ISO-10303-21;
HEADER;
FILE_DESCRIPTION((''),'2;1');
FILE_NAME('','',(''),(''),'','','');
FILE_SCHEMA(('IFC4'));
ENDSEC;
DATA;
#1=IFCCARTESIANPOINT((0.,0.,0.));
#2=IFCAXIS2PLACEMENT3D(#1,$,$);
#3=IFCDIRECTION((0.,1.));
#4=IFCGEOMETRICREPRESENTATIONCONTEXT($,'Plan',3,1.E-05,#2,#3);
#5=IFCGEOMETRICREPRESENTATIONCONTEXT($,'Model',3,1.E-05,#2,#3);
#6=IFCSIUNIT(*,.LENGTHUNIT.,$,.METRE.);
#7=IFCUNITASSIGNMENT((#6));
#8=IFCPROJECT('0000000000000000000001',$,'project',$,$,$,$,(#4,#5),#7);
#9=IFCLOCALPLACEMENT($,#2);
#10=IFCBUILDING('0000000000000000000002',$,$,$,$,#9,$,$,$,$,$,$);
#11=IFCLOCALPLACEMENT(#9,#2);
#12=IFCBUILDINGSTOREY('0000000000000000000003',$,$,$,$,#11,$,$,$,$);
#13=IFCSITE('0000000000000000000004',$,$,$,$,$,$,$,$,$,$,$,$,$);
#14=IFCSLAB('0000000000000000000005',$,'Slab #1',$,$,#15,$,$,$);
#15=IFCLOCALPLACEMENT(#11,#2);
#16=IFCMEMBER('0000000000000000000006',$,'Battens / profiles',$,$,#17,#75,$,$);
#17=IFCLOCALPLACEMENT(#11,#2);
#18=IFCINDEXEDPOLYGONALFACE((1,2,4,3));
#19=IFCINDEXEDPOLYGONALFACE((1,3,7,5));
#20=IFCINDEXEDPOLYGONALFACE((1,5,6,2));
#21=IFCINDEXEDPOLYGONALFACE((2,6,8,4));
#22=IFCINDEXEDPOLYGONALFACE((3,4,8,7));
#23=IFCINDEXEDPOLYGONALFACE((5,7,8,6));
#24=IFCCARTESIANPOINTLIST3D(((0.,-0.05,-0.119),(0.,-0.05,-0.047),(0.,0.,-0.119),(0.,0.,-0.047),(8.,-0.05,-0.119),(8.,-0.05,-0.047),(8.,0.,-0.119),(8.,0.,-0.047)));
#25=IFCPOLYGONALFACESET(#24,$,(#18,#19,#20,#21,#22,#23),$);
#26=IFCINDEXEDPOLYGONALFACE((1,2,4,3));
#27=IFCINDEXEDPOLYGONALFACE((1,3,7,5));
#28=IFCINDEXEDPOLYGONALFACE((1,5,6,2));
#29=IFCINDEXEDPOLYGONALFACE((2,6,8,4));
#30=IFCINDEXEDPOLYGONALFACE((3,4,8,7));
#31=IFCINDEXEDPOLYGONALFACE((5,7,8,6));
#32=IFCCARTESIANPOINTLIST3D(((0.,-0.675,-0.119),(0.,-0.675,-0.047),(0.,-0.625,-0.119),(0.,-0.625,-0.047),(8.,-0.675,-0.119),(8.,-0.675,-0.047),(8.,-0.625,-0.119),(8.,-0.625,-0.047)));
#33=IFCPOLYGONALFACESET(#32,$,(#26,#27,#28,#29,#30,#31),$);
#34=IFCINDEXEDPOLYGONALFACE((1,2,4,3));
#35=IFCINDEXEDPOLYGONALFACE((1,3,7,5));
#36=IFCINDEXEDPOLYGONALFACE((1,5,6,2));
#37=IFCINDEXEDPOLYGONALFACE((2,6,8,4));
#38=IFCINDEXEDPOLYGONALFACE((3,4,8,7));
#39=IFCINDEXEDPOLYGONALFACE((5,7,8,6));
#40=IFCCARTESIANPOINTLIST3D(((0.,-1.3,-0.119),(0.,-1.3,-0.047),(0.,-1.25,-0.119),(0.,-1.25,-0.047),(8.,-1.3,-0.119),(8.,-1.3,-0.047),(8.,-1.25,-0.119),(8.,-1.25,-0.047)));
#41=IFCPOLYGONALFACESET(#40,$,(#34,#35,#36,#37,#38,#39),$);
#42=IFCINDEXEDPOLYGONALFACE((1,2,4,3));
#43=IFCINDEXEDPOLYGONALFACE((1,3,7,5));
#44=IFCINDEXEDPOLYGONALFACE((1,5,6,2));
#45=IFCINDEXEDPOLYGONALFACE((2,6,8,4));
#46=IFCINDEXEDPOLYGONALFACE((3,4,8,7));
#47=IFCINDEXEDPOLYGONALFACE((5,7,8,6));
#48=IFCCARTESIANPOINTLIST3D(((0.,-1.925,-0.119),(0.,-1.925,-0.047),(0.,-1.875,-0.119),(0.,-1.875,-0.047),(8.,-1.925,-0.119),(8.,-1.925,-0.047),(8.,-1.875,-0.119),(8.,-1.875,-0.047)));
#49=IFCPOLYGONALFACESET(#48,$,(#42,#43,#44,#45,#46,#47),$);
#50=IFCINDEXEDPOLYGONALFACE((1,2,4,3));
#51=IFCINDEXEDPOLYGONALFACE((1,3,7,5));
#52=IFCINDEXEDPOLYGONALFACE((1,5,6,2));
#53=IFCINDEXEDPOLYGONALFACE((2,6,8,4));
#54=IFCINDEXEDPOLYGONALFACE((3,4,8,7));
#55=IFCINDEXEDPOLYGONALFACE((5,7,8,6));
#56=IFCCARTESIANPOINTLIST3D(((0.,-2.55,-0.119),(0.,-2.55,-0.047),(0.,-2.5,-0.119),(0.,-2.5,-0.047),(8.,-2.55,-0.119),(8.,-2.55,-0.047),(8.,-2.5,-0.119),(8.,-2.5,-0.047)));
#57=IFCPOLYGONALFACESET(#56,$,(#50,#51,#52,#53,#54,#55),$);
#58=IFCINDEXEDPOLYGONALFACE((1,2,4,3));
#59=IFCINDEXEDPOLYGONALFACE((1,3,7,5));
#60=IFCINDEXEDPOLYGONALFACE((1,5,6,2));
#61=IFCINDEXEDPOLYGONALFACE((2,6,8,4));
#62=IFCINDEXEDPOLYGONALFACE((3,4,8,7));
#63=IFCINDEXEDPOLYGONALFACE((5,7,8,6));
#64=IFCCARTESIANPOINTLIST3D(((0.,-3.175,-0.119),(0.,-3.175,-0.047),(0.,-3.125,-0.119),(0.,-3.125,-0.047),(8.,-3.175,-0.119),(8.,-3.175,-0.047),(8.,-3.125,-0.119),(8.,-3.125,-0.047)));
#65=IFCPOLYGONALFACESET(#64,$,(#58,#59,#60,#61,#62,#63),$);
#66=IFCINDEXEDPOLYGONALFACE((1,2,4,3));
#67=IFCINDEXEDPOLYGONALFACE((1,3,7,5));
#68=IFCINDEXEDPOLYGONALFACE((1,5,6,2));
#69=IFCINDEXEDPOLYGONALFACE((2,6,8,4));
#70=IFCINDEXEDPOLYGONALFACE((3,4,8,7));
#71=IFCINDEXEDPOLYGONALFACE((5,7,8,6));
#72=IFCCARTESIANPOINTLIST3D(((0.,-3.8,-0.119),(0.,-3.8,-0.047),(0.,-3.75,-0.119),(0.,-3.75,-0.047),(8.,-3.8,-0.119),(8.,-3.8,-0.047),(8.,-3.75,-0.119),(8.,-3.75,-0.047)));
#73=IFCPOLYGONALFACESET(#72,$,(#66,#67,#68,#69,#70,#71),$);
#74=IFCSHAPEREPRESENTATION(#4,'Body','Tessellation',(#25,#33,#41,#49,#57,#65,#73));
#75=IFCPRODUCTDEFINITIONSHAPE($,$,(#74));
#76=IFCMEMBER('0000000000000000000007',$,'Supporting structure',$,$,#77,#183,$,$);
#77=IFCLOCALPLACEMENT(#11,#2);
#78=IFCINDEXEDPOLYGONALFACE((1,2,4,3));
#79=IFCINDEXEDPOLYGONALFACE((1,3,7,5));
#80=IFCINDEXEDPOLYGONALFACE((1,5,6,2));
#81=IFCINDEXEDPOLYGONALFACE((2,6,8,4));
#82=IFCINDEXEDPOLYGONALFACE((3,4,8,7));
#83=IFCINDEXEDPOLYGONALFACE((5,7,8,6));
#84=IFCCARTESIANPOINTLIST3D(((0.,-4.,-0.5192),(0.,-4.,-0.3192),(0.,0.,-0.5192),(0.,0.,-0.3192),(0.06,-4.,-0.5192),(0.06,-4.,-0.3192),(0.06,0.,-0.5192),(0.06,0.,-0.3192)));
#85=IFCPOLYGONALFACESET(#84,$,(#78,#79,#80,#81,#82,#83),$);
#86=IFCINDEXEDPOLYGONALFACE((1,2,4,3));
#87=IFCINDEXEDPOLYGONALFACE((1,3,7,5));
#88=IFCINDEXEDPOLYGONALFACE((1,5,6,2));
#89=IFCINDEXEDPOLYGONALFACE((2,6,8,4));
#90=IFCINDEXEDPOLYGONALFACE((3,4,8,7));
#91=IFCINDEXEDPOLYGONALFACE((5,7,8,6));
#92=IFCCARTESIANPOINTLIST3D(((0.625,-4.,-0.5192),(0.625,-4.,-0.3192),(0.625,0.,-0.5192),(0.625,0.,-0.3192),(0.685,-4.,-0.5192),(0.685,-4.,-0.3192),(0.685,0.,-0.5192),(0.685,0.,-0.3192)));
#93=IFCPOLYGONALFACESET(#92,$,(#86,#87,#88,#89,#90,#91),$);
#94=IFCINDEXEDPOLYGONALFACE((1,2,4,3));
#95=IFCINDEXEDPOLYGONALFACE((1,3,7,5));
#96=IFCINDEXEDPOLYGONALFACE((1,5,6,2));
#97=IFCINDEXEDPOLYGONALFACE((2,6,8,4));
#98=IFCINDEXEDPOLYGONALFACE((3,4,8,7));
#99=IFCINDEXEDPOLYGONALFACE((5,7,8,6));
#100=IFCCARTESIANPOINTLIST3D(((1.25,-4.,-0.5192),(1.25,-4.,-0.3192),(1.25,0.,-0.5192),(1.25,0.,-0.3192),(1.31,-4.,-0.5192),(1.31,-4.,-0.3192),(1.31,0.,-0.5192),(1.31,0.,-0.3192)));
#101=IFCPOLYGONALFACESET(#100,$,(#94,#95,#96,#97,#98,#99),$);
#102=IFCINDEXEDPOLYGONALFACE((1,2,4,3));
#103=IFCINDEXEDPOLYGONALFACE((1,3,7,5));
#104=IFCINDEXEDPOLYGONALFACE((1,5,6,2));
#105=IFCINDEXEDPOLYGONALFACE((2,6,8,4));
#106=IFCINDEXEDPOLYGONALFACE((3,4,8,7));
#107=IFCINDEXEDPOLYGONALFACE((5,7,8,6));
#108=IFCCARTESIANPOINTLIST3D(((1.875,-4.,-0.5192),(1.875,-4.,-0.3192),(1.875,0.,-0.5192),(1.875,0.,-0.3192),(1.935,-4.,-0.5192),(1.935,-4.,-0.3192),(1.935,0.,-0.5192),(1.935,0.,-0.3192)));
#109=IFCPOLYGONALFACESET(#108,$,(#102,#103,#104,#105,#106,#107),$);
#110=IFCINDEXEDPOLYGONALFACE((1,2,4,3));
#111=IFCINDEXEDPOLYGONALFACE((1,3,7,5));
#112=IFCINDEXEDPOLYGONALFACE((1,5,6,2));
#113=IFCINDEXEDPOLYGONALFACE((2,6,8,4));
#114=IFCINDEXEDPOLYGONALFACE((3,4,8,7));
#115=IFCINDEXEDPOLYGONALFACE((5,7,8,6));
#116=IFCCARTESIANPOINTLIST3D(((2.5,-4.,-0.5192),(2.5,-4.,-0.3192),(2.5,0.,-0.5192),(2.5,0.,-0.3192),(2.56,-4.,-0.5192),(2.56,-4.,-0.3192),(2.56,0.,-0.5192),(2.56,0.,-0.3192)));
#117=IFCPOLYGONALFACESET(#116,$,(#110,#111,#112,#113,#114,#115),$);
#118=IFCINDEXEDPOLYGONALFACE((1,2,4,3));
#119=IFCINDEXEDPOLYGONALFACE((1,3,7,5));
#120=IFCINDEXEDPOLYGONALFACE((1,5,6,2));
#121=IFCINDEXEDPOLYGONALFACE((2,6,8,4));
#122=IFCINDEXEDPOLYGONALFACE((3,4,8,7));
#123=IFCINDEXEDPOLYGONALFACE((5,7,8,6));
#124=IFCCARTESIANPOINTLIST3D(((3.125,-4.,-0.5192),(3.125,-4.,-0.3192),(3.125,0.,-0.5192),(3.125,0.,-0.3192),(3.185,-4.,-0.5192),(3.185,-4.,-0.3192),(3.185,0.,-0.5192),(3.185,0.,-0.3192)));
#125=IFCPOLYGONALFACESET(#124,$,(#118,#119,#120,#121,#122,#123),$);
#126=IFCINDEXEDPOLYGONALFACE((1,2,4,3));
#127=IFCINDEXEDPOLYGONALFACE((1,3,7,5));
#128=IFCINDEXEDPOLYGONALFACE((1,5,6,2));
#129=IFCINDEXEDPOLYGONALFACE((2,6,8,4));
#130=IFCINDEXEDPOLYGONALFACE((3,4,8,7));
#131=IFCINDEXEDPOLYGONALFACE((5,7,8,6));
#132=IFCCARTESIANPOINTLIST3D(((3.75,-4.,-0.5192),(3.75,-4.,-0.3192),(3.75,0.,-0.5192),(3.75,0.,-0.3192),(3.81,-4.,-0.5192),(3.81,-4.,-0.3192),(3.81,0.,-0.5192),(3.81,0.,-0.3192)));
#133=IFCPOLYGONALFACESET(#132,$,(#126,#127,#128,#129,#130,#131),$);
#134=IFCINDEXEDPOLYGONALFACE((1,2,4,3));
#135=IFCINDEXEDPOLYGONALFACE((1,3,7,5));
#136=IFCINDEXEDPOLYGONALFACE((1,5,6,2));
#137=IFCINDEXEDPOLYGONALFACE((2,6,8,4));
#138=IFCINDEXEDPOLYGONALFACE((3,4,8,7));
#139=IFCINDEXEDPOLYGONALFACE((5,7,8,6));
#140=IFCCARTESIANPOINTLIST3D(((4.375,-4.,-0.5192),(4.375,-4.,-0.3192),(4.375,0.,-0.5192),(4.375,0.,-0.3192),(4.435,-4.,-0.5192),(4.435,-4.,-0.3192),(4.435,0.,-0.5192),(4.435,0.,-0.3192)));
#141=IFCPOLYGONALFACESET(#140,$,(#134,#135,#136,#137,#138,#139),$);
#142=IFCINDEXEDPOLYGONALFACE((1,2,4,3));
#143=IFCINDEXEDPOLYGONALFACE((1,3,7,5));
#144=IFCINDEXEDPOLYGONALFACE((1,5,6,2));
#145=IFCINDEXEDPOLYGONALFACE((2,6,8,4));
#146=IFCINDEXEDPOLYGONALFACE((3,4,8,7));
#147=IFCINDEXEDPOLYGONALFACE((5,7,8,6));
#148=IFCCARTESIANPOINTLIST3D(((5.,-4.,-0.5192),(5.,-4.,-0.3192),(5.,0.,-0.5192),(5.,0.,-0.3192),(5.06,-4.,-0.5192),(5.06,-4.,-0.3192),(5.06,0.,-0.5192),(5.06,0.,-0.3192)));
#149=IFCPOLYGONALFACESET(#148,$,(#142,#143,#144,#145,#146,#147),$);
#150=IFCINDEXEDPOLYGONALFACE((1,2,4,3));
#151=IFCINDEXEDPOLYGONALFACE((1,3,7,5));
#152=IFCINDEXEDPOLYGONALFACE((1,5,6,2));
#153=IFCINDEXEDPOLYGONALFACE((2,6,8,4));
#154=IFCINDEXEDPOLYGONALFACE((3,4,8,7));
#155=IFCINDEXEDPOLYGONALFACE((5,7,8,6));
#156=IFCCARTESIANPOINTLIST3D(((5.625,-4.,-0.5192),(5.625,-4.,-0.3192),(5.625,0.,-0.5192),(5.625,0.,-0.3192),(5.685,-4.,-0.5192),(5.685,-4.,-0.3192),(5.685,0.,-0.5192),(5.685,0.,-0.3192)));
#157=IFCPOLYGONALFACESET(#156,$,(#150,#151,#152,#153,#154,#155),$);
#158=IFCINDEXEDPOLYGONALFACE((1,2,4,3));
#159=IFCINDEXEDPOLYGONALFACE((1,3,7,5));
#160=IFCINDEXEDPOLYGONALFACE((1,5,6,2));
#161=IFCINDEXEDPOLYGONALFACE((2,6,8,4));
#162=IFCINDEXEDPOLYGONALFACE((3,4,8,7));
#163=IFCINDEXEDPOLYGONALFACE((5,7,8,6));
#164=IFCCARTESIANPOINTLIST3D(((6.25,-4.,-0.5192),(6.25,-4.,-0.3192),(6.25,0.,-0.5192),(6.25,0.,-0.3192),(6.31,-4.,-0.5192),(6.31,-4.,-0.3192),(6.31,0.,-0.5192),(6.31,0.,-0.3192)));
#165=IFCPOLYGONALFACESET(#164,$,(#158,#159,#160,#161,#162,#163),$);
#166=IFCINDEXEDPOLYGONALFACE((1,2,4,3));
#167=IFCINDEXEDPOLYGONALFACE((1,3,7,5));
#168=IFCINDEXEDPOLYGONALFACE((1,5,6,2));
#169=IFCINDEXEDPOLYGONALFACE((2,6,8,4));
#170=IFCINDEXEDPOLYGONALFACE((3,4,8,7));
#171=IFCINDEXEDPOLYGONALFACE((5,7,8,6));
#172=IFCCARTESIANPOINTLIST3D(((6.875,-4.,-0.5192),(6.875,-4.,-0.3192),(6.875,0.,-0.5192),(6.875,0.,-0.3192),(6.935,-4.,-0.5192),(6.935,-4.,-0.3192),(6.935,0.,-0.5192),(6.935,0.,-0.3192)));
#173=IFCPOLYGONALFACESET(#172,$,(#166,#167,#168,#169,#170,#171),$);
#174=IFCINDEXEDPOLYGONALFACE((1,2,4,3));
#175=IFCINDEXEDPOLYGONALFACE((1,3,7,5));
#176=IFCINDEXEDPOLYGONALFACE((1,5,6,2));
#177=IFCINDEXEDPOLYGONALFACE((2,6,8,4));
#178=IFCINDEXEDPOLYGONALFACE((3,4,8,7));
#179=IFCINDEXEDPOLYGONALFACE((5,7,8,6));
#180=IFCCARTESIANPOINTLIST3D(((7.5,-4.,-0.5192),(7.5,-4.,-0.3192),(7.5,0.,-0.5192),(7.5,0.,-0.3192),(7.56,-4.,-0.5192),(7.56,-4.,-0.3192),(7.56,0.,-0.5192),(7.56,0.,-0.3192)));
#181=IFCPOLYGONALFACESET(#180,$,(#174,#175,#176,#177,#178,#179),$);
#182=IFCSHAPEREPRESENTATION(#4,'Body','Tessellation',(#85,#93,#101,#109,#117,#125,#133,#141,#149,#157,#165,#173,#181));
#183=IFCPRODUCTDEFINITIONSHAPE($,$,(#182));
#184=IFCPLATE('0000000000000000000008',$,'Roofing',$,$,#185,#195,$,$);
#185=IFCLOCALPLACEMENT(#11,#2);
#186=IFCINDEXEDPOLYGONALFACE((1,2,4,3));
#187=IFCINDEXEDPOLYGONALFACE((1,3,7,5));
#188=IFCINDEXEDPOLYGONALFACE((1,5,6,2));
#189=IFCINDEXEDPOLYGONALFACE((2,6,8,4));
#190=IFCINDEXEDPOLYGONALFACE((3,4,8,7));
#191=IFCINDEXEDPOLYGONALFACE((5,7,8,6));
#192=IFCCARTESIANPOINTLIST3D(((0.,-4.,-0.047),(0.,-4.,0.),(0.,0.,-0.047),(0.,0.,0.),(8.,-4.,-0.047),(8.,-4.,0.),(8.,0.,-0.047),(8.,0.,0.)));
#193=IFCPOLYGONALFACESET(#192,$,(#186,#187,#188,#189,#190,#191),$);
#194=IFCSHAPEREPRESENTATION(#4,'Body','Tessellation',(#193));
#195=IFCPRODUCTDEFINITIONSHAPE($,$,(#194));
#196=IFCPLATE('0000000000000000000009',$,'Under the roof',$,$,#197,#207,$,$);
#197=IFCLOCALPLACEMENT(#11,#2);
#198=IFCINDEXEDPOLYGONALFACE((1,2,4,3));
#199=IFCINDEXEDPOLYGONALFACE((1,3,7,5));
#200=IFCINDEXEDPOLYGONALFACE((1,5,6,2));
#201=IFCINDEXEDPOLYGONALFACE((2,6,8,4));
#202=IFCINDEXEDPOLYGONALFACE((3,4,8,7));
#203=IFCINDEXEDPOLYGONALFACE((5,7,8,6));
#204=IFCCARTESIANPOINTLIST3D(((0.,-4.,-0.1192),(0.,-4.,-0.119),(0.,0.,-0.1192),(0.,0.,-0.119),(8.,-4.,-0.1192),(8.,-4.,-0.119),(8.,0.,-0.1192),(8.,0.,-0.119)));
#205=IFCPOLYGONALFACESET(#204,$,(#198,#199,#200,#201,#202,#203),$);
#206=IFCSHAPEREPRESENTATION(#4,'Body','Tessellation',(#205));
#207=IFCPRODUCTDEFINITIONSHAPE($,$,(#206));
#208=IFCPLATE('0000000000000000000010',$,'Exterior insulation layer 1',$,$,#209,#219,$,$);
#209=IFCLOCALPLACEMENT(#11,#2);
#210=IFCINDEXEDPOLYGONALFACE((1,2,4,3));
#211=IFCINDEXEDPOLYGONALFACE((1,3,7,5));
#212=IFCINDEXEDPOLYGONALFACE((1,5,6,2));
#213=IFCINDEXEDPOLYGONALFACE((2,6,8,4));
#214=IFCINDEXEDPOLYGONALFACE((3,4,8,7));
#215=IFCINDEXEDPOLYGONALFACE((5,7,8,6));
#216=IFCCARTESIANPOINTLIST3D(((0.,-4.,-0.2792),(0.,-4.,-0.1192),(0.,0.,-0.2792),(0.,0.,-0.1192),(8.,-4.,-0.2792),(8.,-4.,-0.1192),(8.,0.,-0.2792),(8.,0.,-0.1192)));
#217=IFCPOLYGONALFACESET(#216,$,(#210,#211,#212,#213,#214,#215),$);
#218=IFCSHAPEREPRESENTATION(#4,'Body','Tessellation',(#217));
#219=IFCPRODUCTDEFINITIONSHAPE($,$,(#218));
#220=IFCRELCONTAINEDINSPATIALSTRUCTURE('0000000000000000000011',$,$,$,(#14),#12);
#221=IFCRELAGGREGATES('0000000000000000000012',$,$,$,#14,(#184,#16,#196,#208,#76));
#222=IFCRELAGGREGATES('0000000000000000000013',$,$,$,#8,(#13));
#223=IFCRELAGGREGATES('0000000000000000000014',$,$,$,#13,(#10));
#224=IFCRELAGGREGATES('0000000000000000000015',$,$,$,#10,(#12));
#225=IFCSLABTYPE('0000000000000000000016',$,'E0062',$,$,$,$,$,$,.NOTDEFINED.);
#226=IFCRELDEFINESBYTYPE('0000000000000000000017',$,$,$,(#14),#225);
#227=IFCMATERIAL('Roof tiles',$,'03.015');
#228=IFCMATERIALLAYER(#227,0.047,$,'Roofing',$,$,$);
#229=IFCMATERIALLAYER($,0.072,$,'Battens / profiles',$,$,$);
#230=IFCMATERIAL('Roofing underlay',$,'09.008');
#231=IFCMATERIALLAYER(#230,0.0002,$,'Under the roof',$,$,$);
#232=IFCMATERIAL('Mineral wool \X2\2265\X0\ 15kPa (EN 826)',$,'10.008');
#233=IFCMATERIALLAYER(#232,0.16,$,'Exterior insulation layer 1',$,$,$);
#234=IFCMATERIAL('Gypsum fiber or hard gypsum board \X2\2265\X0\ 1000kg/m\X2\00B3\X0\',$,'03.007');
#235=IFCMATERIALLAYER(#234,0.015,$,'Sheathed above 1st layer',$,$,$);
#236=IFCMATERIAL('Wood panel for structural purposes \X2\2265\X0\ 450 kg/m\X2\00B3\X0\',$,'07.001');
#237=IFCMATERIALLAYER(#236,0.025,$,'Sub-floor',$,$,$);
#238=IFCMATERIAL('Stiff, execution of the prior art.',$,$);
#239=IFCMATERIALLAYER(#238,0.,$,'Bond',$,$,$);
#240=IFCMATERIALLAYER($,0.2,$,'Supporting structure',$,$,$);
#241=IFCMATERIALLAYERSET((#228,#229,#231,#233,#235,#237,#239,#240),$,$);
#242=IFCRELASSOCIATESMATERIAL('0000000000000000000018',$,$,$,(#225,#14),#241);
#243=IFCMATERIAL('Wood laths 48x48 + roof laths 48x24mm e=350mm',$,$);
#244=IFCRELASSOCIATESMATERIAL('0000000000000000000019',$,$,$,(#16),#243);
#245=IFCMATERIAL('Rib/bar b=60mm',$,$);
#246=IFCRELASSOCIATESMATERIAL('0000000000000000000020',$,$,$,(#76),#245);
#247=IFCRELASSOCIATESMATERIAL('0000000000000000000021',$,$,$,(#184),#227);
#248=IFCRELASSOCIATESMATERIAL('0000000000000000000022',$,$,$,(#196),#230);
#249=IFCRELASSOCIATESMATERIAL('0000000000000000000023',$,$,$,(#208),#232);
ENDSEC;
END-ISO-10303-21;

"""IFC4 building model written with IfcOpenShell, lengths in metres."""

from ifc_helpers import new_model, si_unit, direction, frame, frame_2d, origin, origin_with_axes, place, context, project, spatial, rectangle, extrude, material, layer, layer_set, type_object, element, aggregate, save


model = new_model("IFC4")

# Units and contexts
plan_context = context("Plan", 3, precision=1e-05, world=origin(), true_north=direction((0.0, 1.0)))
model_context = context("Model", 3, precision=1e-05, world=origin(), true_north=direction((0.0, 1.0)))
ifc_project = project(units=[si_unit("LENGTHUNIT", "METRE")], contexts=[plan_context, model_context])

# Site, building, storey
site = spatial("IfcSite", under=ifc_project)
building_placement = place(None, origin())
building = spatial("IfcBuilding", under=site, at=building_placement)
storey_placement = place(building_placement, origin())
storey = spatial("IfcBuildingStorey", under=building, at=storey_placement)

# Slab, members, plates
ifc_material_1 = material(Name="Roof tiles", Category="03.015")
ifc_layer_1 = layer(ifc_material_1, 0.047, Name="Roofing")
ifc_layer_2 = layer(None, 0.072, Name="Battens / profiles")
ifc_material_2 = material(Name="Roofing underlay", Category="09.008")
ifc_layer_3 = layer(ifc_material_2, 0.0002, Name="Under the roof")
ifc_material_3 = material(Name="Mineral wool ≥ 15kPa (EN 826)", Category="10.008")
ifc_layer_4 = layer(ifc_material_3, 0.16, Name="Exterior insulation layer 1")
ifc_material_4 = material(Name="Gypsum fiber or hard gypsum board ≥ 1000kg/m³", Category="03.007")
ifc_layer_5 = layer(ifc_material_4, 0.015, Name="Sheathed above 1st layer")
ifc_material_5 = material(Name="Wood panel for structural purposes ≥ 450 kg/m³", Category="07.001")
ifc_layer_6 = layer(ifc_material_5, 0.025, Name="Sub-floor")
ifc_material_6 = material(Name="Stiff, execution of the prior art.")
ifc_layer_7 = layer(ifc_material_6, 0.0, Name="Bond")
ifc_layer_8 = layer(None, 0.2, Name="Supporting structure")
ifc_layer_set = layer_set([ifc_layer_1, ifc_layer_2, ifc_layer_3, ifc_layer_4, ifc_layer_5, ifc_layer_6, ifc_layer_7, ifc_layer_8])
slab_type = type_object("IfcSlabType", Name="E0062", PredefinedType="NOTDEFINED", material=ifc_layer_set)
slab_placement = place(None, frame((0.0, 0.0, 0.0), z_axis=(0.0, 0.0, -1.0), x_axis=(1.0, 0.0, 0.0)))
slab = element("IfcSlab", 1, at=slab_placement, inside=storey, type_object=slab_type, material=ifc_layer_set, Name="Slab #1")
ifc_material_7 = material(Name="Wood laths 48x48 + roof laths 48x24mm e=350mm")
member_1_placement = place(slab_placement, origin())
member_1 = element("IfcMember", 2, at=member_1_placement, material=ifc_material_7, Name="Battens / profiles", context=plan_context, shape_type="SweptSolid", body=[
    extrude(rectangle(XDim=0.05, YDim=0.072, at=frame_2d((0.025, 0.036), x_axis=(1.0, 0.0))), frame((0.0, 0.0, 0.047), z_axis=(1.0, 0.0, 0.0), x_axis=(0.0, 1.0, 0.0)), (0.0, 0.0, 1.0), 8.0),
    extrude(rectangle(XDim=0.05, YDim=0.072, at=frame_2d((0.025, 0.036), x_axis=(1.0, 0.0))), frame((0.0, 0.625, 0.047), z_axis=(1.0, 0.0, 0.0), x_axis=(0.0, 1.0, 0.0)), (0.0, 0.0, 1.0), 8.0),
    extrude(rectangle(XDim=0.05, YDim=0.072, at=frame_2d((0.025, 0.036), x_axis=(1.0, 0.0))), frame((0.0, 1.25, 0.047), z_axis=(1.0, 0.0, 0.0), x_axis=(0.0, 1.0, 0.0)), (0.0, 0.0, 1.0), 8.0),
    extrude(rectangle(XDim=0.05, YDim=0.072, at=frame_2d((0.025, 0.036), x_axis=(1.0, 0.0))), frame((0.0, 1.875, 0.047), z_axis=(1.0, 0.0, 0.0), x_axis=(0.0, 1.0, 0.0)), (0.0, 0.0, 1.0), 8.0),
    extrude(rectangle(XDim=0.05, YDim=0.072, at=frame_2d((0.025, 0.036), x_axis=(1.0, 0.0))), frame((0.0, 2.5, 0.047), z_axis=(1.0, 0.0, 0.0), x_axis=(0.0, 1.0, 0.0)), (0.0, 0.0, 1.0), 8.0),
    extrude(rectangle(XDim=0.05, YDim=0.072, at=frame_2d((0.025, 0.036), x_axis=(1.0, 0.0))), frame((0.0, 3.125, 0.047), z_axis=(1.0, 0.0, 0.0), x_axis=(0.0, 1.0, 0.0)), (0.0, 0.0, 1.0), 8.0),
    extrude(rectangle(XDim=0.05, YDim=0.072, at=frame_2d((0.025, 0.036), x_axis=(1.0, 0.0))), frame((0.0, 3.75, 0.047), z_axis=(1.0, 0.0, 0.0), x_axis=(0.0, 1.0, 0.0)), (0.0, 0.0, 1.0), 8.0),
])
ifc_material_8 = material(Name="Rib/bar b=60mm")
member_2_placement = place(slab_placement, origin())
member_2 = element("IfcMember", 3, at=member_2_placement, material=ifc_material_8, Name="Supporting structure", context=plan_context, shape_type="SweptSolid", body=[
    extrude(rectangle(XDim=0.06, YDim=0.2, at=frame_2d((0.03, 0.1), x_axis=(1.0, 0.0))), frame((0.0, 4.0, 0.3192), z_axis=(0.0, -1.0, 0.0), x_axis=(1.0, 0.0, 0.0)), (0.0, 0.0, 1.0), 4.0),
    extrude(rectangle(XDim=0.06, YDim=0.2, at=frame_2d((0.03, 0.1), x_axis=(1.0, 0.0))), frame((0.625, 4.0, 0.3192), z_axis=(0.0, -1.0, 0.0), x_axis=(1.0, 0.0, 0.0)), (0.0, 0.0, 1.0), 4.0),
    extrude(rectangle(XDim=0.06, YDim=0.2, at=frame_2d((0.03, 0.1), x_axis=(1.0, 0.0))), frame((1.25, 4.0, 0.3192), z_axis=(0.0, -1.0, 0.0), x_axis=(1.0, 0.0, 0.0)), (0.0, 0.0, 1.0), 4.0),
    extrude(rectangle(XDim=0.06, YDim=0.2, at=frame_2d((0.03, 0.1), x_axis=(1.0, 0.0))), frame((1.875, 4.0, 0.3192), z_axis=(0.0, -1.0, 0.0), x_axis=(1.0, 0.0, 0.0)), (0.0, 0.0, 1.0), 4.0),
    extrude(rectangle(XDim=0.06, YDim=0.2, at=frame_2d((0.03, 0.1), x_axis=(1.0, 0.0))), frame((2.5, 4.0, 0.3192), z_axis=(0.0, -1.0, 0.0), x_axis=(1.0, 0.0, 0.0)), (0.0, 0.0, 1.0), 4.0),
    extrude(rectangle(XDim=0.06, YDim=0.2, at=frame_2d((0.03, 0.1), x_axis=(1.0, 0.0))), frame((3.125, 4.0, 0.3192), z_axis=(0.0, -1.0, 0.0), x_axis=(1.0, 0.0, 0.0)), (0.0, 0.0, 1.0), 4.0),
    extrude(rectangle(XDim=0.06, YDim=0.2, at=frame_2d((0.03, 0.1), x_axis=(1.0, 0.0))), frame((3.75, 4.0, 0.3192), z_axis=(0.0, -1.0, 0.0), x_axis=(1.0, 0.0, 0.0)), (0.0, 0.0, 1.0), 4.0),
    extrude(rectangle(XDim=0.06, YDim=0.2, at=frame_2d((0.03, 0.1), x_axis=(1.0, 0.0))), frame((4.375, 4.0, 0.3192), z_axis=(0.0, -1.0, 0.0), x_axis=(1.0, 0.0, 0.0)), (0.0, 0.0, 1.0), 4.0),
    extrude(rectangle(XDim=0.06, YDim=0.2, at=frame_2d((0.03, 0.1), x_axis=(1.0, 0.0))), frame((5.0, 4.0, 0.3192), z_axis=(0.0, -1.0, 0.0), x_axis=(1.0, 0.0, 0.0)), (0.0, 0.0, 1.0), 4.0),
    extrude(rectangle(XDim=0.06, YDim=0.2, at=frame_2d((0.03, 0.1), x_axis=(1.0, 0.0))), frame((5.625, 4.0, 0.3192), z_axis=(0.0, -1.0, 0.0), x_axis=(1.0, 0.0, 0.0)), (0.0, 0.0, 1.0), 4.0),
    extrude(rectangle(XDim=0.06, YDim=0.2, at=frame_2d((0.03, 0.1), x_axis=(1.0, 0.0))), frame((6.25, 4.0, 0.3192), z_axis=(0.0, -1.0, 0.0), x_axis=(1.0, 0.0, 0.0)), (0.0, 0.0, 1.0), 4.0),
    extrude(rectangle(XDim=0.06, YDim=0.2, at=frame_2d((0.03, 0.1), x_axis=(1.0, 0.0))), frame((6.875, 4.0, 0.3192), z_axis=(0.0, -1.0, 0.0), x_axis=(1.0, 0.0, 0.0)), (0.0, 0.0, 1.0), 4.0),
    extrude(rectangle(XDim=0.06, YDim=0.2, at=frame_2d((0.03, 0.1), x_axis=(1.0, 0.0))), frame((7.5, 4.0, 0.3192), z_axis=(0.0, -1.0, 0.0), x_axis=(1.0, 0.0, 0.0)), (0.0, 0.0, 1.0), 4.0),
])
plate_1_placement = place(slab_placement, origin())
plate_1 = element("IfcPlate", 4, at=plate_1_placement, material=ifc_material_1, Name="Roofing", context=plan_context, shape_type="SweptSolid", body=[
    extrude(rectangle(XDim=8.0, YDim=4.0, at=frame_2d((4.0, 2.0), x_axis=(1.0, 0.0))), origin_with_axes(), (0.0, 0.0, 1.0), 0.047),
])
plate_2_placement = place(slab_placement, origin())
plate_2 = element("IfcPlate", 5, at=plate_2_placement, material=ifc_material_2, Name="Under the roof", context=plan_context, shape_type="SweptSolid", body=[
    extrude(rectangle(XDim=8.0, YDim=4.0, at=frame_2d((4.0, 2.0), x_axis=(1.0, 0.0))), frame((0.0, 0.0, 0.119), z_axis=(0.0, 0.0, 1.0), x_axis=(1.0, 0.0, 0.0)), (0.0, 0.0, 1.0), 0.0002),
])
plate_3_placement = place(slab_placement, origin())
plate_3 = element("IfcPlate", 6, at=plate_3_placement, material=ifc_material_3, Name="Exterior insulation layer 1", context=plan_context, shape_type="SweptSolid", body=[
    extrude(rectangle(XDim=8.0, YDim=4.0, at=frame_2d((4.0, 2.0), x_axis=(1.0, 0.0))), frame((0.0, 0.0, 0.1192), z_axis=(0.0, 0.0, 1.0), x_axis=(1.0, 0.0, 0.0)), (0.0, 0.0, 1.0), 0.16),
])
aggregate(slab, [plate_1, member_1, plate_2, plate_3, member_2])

save(model, "model.ifc")
